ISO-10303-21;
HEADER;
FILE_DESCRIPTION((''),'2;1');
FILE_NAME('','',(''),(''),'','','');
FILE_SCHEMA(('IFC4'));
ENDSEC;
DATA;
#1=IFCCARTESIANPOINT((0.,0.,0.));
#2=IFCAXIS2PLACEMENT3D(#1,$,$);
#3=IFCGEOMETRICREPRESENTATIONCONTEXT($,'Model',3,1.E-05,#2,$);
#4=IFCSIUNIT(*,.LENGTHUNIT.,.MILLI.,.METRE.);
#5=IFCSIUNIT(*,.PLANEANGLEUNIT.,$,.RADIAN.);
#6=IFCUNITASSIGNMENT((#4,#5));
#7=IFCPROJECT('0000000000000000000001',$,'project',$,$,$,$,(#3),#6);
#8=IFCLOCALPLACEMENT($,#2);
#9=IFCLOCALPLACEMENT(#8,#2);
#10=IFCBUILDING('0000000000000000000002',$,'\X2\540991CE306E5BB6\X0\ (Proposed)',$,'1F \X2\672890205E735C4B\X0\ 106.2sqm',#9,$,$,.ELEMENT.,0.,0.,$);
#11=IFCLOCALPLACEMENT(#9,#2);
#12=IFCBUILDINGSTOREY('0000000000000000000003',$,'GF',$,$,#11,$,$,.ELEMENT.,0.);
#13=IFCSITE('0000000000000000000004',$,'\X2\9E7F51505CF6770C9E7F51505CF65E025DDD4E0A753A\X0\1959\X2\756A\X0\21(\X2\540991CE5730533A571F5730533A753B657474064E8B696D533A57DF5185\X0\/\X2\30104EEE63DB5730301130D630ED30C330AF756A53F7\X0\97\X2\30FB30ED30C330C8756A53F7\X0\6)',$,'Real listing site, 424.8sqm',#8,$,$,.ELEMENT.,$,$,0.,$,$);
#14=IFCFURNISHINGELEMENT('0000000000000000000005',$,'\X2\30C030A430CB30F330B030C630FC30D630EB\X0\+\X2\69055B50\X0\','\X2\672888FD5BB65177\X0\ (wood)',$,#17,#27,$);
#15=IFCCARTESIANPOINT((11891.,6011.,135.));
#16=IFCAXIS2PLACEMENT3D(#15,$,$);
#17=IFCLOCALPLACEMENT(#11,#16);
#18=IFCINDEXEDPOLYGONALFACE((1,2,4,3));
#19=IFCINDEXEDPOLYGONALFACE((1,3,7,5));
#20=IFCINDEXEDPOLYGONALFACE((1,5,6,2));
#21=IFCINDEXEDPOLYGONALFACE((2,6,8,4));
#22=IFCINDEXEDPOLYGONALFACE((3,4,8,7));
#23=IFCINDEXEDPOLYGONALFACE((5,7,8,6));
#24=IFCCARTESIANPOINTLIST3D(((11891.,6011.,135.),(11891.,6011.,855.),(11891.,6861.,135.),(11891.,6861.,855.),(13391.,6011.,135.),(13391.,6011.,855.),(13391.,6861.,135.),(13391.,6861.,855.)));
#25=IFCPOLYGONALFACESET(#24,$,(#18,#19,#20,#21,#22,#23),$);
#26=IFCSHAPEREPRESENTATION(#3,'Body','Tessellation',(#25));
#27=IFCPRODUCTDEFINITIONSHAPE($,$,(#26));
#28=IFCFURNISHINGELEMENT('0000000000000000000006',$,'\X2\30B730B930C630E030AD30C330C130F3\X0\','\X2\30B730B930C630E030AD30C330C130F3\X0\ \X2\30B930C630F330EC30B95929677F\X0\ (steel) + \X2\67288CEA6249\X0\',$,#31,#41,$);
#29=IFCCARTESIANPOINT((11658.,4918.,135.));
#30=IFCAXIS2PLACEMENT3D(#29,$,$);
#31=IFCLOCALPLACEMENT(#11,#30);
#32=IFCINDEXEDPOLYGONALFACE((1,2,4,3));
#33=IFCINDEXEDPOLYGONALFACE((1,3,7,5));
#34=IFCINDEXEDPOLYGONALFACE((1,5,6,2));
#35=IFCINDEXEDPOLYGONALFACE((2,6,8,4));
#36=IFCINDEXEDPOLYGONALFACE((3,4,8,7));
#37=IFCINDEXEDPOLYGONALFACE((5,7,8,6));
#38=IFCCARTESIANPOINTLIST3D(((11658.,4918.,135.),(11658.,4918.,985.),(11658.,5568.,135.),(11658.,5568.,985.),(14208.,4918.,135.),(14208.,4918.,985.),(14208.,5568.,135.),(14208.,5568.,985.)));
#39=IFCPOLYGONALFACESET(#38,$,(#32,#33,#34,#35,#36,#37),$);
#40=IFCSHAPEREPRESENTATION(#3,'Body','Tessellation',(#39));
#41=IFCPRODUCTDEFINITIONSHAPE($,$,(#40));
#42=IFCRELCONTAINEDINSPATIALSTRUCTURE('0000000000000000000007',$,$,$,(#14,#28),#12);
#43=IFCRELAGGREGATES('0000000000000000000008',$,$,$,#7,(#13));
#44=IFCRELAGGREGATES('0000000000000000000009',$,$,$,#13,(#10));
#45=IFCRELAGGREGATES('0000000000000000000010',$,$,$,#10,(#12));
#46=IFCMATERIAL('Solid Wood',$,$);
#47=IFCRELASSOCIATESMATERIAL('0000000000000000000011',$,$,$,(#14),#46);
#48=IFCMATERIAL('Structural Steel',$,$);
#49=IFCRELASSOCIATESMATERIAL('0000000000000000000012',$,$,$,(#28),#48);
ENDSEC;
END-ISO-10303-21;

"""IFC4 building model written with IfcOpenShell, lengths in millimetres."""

from ifc_helpers import new_model, si_unit, frame, frame_2d, origin, place, context, project, spatial, rectangle, extrude, material, element, save


model = new_model("IFC4")

# Units and contexts
model_context = context("Model", 3, precision=1e-05, world=origin())
ifc_project = project(units=[si_unit("LENGTHUNIT", "METRE", prefix="MILLI"), si_unit("PLANEANGLEUNIT", "RADIAN")], contexts=[model_context])

# Site, building, storey
site_placement = place(None, origin())
site = spatial("IfcSite", under=ifc_project, at=site_placement, Name="鹿児島県鹿児島市川上町1959番21(吉野地区土地区画整理事業区域内/【仮換地】ブロック番号97・ロット番号6)", ObjectType="Real listing site, 424.8sqm", CompositionType="ELEMENT", RefElevation=0.0)
building_placement = place(site_placement, origin())
building = spatial("IfcBuilding", under=site, at=building_placement, Name="吉野の家 (Proposed)", ObjectType="1F 木造平屋 106.2sqm", CompositionType="ELEMENT", ElevationOfRefHeight=0.0, ElevationOfTerrain=0.0)
storey_placement = place(building_placement, origin())
storey = spatial("IfcBuildingStorey", under=building, at=storey_placement, Name="GF", CompositionType="ELEMENT", Elevation=0.0)

# Shared definitions
ifc_material_1 = material(Name="Solid Wood")

# Shared definitions
ifc_material_2 = material(Name="Structural Steel")

# Furnishing elements
furnishing_1_placement = place(storey_placement, frame((11891.0, 6011.0, 135.0)))
element("IfcFurnishingElement", 1, at=furnishing_1_placement, inside=storey, material=ifc_material_1, Name="ダイニングテーブル+椅子", Description="木製家具 (wood)", context=model_context, shape_type="SweptSolid", body=[
    extrude(rectangle(XDim=1500.0, YDim=850.0, at=frame_2d((750.0, 425.0))), frame((11891.0, 6011.0, 135.0)), (0.0, 0.0, 1.0), 720.0),
])
furnishing_2_placement = place(storey_placement, frame((11658.0, 4918.0, 135.0)))
element("IfcFurnishingElement", 2, at=furnishing_2_placement, inside=storey, material=ifc_material_2, Name="システムキッチン", Description="システムキッチン ステンレス天板 (steel) + 木質扉", context=model_context, shape_type="SweptSolid", body=[
    extrude(rectangle(XDim=2550.0, YDim=650.0, at=frame_2d((1275.0, 325.0))), frame((11658.0, 4918.0, 135.0)), (0.0, 0.0, 1.0), 850.0),
])

save(model, "model.ifc")
